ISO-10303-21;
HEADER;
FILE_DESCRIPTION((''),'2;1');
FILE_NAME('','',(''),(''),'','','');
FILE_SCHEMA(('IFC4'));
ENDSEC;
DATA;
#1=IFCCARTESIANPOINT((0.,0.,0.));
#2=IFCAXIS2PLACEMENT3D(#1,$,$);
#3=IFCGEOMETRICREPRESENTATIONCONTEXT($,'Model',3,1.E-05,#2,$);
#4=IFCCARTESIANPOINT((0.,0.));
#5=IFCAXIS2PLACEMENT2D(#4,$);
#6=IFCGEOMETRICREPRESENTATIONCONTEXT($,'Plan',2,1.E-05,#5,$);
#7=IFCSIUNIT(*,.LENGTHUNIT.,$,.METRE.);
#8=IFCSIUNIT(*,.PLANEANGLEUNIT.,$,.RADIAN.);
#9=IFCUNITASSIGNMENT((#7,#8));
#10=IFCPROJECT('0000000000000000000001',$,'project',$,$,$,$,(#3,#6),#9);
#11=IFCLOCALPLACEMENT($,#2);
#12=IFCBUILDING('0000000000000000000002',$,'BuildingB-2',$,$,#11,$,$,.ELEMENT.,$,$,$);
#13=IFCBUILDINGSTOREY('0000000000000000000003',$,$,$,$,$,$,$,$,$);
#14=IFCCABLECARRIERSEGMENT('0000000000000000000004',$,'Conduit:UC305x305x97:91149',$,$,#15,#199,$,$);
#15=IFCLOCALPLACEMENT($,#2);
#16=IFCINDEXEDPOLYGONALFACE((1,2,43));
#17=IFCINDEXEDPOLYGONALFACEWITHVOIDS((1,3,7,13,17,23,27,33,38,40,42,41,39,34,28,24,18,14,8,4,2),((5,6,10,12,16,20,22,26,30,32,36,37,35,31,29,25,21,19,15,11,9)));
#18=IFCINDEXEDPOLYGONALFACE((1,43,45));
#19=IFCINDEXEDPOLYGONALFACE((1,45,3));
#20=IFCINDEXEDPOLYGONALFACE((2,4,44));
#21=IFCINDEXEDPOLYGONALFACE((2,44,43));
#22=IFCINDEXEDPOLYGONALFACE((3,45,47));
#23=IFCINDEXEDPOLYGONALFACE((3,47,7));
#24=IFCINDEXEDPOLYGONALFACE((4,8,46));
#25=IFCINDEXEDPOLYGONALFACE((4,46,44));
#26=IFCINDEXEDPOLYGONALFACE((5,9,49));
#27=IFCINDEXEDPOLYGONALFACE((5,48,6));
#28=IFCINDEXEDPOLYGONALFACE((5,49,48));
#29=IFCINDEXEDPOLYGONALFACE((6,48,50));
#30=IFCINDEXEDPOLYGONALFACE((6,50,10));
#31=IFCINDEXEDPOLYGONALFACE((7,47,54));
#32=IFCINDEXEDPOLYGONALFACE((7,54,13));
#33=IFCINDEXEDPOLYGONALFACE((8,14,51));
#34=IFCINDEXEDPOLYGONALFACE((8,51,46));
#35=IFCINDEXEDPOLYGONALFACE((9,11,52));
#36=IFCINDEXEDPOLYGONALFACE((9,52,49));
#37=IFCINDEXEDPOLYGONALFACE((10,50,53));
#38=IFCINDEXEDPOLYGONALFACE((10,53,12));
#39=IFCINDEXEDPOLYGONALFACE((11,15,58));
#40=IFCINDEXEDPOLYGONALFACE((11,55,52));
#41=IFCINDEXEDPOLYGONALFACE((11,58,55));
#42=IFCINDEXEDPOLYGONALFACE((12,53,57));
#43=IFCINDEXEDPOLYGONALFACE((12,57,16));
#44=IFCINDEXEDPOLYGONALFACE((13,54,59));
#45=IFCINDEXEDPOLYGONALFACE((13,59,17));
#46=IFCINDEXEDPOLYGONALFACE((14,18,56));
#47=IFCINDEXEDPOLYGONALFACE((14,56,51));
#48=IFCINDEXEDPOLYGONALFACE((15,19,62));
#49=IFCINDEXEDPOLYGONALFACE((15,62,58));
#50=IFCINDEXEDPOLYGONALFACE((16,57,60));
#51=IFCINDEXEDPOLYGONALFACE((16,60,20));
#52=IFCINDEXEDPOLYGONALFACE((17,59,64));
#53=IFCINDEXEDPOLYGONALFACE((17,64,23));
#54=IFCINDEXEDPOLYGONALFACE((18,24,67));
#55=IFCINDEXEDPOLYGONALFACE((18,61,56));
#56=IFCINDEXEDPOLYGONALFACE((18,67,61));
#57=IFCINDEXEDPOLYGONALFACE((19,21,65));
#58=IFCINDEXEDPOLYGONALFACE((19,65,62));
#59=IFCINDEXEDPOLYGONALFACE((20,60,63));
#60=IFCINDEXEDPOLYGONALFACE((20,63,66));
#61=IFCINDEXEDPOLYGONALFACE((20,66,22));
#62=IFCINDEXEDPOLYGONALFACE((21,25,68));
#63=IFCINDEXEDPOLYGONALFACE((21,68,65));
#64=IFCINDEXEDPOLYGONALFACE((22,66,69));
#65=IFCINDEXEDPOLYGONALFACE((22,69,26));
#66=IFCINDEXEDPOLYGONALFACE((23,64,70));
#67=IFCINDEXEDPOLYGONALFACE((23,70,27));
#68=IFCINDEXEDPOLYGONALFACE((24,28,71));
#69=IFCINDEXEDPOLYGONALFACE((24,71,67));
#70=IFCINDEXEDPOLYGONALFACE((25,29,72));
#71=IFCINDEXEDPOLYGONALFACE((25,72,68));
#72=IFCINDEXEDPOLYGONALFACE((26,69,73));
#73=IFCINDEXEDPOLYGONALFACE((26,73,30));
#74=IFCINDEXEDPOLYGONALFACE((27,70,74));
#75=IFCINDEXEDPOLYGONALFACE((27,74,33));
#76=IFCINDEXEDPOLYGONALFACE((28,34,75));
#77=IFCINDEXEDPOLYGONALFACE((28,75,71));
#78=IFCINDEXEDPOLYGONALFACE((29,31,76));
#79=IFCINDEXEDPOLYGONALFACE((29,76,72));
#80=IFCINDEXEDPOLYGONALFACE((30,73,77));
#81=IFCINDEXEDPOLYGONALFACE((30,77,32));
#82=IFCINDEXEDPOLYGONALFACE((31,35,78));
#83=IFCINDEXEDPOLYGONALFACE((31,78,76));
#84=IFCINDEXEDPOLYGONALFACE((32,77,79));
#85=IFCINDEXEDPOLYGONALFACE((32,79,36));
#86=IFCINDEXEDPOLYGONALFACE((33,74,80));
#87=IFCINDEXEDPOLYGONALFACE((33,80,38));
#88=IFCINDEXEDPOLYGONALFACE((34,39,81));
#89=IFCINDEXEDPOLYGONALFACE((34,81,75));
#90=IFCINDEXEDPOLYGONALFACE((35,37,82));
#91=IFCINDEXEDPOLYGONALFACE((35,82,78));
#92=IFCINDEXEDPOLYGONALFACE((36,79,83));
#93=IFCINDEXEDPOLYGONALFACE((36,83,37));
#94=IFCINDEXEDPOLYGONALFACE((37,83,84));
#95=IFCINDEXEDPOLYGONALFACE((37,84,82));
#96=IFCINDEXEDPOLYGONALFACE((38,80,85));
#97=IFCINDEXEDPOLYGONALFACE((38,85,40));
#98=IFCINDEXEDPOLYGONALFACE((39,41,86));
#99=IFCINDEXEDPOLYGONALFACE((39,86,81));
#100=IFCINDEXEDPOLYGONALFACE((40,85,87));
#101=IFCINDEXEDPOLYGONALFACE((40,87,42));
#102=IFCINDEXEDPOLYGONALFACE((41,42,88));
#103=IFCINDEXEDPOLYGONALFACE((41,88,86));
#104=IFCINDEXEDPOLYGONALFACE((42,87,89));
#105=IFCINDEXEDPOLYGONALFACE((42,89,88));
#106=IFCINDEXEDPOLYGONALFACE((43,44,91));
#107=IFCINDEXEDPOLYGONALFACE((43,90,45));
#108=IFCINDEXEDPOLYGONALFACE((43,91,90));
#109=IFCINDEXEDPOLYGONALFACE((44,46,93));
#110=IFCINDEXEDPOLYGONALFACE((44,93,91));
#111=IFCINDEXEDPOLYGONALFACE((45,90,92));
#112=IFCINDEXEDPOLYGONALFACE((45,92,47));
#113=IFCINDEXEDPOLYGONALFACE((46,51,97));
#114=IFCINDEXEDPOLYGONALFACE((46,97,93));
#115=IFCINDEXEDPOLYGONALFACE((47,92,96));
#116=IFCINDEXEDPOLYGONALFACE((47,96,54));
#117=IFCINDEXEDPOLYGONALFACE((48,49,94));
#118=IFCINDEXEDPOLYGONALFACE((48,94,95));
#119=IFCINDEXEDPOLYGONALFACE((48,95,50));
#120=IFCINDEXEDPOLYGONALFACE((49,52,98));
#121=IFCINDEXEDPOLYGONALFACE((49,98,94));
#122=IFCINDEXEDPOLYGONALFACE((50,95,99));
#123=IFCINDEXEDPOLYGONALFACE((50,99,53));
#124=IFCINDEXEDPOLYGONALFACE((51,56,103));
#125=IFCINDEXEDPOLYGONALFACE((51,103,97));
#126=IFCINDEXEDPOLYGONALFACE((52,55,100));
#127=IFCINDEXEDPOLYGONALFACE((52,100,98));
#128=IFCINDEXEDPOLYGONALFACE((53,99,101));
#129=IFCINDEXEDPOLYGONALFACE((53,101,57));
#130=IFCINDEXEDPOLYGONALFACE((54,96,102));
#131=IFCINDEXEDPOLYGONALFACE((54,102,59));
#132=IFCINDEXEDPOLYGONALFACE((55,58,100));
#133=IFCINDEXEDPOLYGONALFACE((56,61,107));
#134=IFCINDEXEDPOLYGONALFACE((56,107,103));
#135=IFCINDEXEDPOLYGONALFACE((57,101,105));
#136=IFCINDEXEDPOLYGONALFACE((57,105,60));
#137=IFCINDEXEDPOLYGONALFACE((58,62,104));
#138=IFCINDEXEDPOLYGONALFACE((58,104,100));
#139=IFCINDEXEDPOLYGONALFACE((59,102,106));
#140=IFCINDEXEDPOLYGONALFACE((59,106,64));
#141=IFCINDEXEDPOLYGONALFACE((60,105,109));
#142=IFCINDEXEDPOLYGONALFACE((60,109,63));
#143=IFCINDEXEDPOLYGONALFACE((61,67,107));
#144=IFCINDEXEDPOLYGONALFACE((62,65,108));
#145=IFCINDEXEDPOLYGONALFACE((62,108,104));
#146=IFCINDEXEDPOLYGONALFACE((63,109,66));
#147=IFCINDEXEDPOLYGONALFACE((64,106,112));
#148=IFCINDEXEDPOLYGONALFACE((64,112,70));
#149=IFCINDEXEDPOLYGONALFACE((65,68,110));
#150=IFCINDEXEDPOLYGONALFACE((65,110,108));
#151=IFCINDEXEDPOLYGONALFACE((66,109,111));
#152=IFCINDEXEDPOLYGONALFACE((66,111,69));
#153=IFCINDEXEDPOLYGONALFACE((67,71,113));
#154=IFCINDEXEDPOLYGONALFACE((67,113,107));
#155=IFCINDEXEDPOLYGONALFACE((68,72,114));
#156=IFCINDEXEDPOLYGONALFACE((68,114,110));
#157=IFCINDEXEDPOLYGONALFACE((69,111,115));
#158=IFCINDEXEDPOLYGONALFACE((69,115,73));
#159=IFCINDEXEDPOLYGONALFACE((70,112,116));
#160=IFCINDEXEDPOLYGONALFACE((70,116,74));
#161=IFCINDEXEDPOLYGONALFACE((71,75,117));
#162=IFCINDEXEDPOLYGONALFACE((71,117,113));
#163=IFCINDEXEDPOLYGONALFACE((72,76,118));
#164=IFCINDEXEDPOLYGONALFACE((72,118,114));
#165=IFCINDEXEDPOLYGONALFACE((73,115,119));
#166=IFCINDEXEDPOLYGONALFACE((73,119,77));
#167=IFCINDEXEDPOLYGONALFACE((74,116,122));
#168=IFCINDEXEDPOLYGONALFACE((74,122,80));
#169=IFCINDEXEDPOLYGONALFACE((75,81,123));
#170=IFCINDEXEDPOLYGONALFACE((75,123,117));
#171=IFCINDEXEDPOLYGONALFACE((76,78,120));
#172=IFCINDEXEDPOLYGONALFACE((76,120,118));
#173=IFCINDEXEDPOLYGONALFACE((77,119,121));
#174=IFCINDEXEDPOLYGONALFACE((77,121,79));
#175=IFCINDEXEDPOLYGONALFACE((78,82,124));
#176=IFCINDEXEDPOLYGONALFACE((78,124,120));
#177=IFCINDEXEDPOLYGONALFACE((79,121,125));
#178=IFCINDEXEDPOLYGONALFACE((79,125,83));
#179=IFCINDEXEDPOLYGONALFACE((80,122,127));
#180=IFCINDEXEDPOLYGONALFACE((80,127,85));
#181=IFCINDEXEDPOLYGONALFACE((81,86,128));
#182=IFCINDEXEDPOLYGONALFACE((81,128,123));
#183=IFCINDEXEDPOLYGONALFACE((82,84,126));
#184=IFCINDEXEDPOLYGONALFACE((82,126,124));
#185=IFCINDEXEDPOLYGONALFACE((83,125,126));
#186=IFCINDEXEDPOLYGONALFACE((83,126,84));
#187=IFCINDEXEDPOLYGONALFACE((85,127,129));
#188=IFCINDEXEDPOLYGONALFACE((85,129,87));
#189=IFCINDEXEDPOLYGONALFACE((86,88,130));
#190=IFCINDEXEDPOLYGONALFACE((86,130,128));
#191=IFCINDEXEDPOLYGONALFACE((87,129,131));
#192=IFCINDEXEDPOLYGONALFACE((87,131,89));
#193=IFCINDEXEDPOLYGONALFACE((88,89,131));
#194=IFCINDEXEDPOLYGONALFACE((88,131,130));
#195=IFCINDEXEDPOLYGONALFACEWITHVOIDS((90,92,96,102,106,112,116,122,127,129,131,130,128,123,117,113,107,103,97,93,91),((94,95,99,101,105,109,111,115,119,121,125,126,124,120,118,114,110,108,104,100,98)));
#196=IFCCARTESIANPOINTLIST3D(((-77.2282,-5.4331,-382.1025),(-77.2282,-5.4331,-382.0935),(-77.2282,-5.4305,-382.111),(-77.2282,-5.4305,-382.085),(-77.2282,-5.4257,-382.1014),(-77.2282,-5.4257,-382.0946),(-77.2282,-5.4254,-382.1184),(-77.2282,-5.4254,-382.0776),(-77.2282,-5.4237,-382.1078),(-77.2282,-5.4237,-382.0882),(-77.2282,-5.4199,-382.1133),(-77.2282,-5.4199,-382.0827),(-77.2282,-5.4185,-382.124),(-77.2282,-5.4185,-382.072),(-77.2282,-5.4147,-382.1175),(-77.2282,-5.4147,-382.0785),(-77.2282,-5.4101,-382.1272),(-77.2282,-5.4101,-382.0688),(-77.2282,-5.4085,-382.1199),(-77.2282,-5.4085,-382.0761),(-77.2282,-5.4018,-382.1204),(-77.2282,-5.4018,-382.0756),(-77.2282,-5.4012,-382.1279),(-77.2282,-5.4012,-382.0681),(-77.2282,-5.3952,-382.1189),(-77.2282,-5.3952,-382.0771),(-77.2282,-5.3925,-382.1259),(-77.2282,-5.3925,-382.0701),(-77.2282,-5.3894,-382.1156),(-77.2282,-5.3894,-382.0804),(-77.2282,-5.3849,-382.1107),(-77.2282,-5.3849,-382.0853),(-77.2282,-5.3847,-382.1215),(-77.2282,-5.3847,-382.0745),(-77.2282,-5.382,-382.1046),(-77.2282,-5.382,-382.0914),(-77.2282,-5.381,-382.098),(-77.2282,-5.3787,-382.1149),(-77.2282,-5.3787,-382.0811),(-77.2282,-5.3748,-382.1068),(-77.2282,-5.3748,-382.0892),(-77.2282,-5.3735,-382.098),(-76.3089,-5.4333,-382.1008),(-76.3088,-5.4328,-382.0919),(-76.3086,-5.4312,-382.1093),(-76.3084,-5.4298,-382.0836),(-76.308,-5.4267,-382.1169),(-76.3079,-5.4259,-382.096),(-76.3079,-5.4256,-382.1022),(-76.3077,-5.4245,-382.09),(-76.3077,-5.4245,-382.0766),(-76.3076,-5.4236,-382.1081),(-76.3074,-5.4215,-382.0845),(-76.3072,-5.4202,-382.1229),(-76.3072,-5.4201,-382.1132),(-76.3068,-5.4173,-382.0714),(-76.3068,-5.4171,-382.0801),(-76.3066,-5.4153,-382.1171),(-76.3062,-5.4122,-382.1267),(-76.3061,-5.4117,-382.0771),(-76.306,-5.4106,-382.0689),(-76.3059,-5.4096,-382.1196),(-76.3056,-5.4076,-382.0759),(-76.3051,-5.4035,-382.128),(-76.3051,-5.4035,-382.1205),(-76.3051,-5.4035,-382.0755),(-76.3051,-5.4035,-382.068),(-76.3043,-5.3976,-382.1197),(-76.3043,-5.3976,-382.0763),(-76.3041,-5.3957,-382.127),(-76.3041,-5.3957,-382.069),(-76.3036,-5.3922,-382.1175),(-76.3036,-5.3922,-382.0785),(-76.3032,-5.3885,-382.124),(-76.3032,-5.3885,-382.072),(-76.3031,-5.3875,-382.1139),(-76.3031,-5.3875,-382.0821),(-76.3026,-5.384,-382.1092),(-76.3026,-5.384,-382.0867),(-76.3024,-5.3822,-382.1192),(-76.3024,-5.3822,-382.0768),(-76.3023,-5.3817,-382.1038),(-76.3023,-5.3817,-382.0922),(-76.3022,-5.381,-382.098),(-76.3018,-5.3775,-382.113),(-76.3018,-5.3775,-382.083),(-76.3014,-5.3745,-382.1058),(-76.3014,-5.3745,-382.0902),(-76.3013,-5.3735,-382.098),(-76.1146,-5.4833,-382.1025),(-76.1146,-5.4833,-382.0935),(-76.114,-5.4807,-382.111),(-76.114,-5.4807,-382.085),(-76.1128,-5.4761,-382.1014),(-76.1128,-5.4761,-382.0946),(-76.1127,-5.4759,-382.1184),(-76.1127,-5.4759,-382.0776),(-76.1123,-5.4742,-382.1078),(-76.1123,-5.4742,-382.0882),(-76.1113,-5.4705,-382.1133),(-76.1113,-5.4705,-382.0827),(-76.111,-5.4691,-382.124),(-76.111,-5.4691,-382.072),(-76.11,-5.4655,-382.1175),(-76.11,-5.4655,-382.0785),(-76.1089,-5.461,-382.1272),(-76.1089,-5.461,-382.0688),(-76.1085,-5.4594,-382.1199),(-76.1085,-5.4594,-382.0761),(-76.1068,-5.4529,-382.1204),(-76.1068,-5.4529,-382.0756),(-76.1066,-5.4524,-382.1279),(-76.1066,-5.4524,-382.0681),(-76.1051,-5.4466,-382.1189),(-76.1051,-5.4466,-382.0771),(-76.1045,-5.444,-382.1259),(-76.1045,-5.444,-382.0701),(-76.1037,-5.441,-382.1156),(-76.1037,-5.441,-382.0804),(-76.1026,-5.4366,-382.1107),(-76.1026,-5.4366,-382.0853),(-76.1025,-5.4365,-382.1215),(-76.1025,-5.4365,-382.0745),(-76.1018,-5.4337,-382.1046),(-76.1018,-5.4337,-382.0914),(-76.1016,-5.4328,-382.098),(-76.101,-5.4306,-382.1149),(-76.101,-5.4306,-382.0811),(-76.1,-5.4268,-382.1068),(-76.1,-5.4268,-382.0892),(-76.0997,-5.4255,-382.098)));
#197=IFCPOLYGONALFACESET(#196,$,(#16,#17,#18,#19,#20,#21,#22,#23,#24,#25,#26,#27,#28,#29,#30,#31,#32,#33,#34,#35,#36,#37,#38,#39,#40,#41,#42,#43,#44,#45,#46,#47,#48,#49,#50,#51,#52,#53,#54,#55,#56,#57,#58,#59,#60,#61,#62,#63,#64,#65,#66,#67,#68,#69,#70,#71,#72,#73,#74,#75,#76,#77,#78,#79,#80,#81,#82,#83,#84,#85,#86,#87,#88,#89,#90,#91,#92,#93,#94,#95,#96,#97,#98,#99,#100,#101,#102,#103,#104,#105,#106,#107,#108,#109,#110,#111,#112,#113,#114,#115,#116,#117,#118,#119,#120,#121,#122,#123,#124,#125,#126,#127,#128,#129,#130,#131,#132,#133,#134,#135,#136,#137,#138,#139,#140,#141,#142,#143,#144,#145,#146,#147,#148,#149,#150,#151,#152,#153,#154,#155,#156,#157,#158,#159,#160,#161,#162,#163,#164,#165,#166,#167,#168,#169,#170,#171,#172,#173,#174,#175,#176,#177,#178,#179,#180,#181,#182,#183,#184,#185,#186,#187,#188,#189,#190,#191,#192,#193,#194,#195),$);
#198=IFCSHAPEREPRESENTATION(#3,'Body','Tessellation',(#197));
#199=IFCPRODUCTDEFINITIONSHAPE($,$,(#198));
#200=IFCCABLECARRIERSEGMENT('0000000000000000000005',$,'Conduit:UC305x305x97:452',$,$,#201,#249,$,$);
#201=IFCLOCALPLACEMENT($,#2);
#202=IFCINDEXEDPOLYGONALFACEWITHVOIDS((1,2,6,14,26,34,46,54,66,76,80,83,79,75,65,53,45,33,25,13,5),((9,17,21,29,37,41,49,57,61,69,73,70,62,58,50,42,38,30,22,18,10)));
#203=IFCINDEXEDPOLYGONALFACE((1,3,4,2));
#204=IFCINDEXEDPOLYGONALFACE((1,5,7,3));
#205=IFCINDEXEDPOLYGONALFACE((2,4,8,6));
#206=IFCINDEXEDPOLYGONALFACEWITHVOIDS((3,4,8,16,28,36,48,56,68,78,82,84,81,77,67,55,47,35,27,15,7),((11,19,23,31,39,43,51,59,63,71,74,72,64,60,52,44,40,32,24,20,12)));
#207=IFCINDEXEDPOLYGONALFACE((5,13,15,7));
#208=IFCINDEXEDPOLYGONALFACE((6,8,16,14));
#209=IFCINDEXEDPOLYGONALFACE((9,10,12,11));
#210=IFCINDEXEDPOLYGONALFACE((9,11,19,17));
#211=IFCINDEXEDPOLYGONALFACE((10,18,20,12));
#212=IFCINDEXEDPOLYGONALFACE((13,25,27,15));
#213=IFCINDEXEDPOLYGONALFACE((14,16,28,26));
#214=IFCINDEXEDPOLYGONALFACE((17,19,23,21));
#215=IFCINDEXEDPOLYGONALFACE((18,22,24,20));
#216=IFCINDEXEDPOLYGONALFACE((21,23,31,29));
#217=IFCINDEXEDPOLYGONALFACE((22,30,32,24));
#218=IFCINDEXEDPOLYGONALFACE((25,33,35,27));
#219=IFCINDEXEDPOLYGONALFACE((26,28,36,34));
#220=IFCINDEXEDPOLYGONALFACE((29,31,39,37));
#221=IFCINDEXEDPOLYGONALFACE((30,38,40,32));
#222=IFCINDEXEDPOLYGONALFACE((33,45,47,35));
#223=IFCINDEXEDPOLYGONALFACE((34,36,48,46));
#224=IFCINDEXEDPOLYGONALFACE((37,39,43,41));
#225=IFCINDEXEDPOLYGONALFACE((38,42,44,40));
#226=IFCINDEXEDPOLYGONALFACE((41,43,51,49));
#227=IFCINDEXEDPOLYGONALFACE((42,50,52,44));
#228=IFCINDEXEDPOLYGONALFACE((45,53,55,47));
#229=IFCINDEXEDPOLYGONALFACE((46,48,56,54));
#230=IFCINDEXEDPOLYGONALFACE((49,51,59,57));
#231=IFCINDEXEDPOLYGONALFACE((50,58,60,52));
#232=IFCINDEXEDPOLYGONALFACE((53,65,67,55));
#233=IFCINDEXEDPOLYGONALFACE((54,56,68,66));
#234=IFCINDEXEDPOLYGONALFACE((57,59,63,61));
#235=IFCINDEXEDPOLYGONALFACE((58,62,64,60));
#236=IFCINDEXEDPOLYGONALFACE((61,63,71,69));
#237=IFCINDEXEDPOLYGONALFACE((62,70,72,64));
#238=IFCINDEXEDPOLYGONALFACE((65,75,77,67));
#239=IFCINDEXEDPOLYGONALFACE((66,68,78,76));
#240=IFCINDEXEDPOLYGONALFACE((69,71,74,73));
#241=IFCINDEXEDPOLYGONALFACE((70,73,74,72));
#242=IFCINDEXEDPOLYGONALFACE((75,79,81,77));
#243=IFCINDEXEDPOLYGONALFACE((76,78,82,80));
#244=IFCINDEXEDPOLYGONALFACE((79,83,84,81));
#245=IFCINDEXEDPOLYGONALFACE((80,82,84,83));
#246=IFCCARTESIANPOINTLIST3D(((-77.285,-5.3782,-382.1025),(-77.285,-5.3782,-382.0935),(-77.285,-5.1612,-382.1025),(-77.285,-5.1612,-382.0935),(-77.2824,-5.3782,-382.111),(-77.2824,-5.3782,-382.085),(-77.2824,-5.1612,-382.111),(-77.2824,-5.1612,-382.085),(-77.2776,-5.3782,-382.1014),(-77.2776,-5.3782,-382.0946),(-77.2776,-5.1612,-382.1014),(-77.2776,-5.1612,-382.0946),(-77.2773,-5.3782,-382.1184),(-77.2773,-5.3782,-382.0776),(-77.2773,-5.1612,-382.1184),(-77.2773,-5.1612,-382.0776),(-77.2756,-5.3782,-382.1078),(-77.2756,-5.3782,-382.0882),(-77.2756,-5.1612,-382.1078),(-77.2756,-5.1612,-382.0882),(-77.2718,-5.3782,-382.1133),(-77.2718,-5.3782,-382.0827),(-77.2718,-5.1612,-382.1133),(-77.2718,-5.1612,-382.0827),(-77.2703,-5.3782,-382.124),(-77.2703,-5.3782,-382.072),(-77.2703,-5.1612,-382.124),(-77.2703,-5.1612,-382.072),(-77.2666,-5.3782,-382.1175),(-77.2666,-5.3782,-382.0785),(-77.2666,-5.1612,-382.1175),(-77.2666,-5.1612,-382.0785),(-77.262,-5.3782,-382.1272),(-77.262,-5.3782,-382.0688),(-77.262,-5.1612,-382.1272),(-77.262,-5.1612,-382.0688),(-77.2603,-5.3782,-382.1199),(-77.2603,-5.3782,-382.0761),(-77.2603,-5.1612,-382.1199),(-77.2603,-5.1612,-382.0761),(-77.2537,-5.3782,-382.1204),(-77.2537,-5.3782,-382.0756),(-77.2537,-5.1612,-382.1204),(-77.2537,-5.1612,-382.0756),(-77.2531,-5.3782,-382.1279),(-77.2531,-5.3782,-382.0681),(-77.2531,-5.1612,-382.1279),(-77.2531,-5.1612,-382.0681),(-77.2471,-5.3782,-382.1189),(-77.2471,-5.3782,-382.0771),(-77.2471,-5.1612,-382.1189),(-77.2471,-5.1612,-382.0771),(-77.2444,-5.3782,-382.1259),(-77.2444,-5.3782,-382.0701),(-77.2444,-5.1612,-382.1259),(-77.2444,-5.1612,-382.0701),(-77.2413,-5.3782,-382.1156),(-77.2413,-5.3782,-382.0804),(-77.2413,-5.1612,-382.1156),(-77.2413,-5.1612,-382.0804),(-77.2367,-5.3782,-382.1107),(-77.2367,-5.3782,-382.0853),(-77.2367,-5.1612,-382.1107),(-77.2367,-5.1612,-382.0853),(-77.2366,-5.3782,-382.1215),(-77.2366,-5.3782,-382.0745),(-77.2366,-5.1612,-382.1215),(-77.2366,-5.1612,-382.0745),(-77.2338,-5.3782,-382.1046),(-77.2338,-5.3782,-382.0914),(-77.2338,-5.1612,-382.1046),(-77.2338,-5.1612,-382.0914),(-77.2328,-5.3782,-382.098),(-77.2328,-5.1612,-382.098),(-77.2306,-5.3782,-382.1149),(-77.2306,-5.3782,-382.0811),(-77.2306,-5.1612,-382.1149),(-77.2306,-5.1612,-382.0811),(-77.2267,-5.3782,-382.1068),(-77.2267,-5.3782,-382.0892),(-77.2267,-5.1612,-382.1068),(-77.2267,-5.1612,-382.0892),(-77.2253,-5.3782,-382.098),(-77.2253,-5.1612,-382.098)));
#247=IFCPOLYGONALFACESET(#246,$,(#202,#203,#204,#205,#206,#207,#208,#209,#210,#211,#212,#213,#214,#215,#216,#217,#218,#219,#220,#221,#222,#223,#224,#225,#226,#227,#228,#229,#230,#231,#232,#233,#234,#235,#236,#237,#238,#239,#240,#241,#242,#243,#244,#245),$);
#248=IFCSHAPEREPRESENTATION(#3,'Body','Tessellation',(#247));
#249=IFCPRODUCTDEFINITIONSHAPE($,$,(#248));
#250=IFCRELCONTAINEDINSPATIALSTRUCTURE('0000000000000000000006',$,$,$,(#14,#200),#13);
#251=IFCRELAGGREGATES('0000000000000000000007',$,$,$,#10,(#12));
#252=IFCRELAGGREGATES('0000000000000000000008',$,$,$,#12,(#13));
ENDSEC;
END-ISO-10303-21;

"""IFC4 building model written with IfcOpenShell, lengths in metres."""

from ifc_helpers import new_model, entity, si_unit, origin, origin_2d, place, context, project, spatial, element, save


model = new_model("IFC4")

# Units and contexts
model_context = context("Model", 3, precision=1e-05, world=origin())
plan_context = context("Plan", 2, precision=1e-05, world=origin_2d())
ifc_project = project(units=[si_unit("LENGTHUNIT", "METRE"), si_unit("PLANEANGLEUNIT", "RADIAN")], contexts=[model_context, plan_context])

# Building, storey
building_placement = place(None, origin())
building = spatial("IfcBuilding", under=ifc_project, at=building_placement, Name="BuildingB-2", CompositionType="ELEMENT")
storey = spatial("IfcBuildingStorey", under=building)

# Cable carrier segments
element("IfcCableCarrierSegment", 1, inside=storey, Name="Conduit:UC305x305x97:91149", context=model_context, shape_type="AdvancedSweptSolid", body=[
    entity("IfcSweptDiskSolid", entity("IfcCompositeCurve", [entity("IfcCompositeCurveSegment", "CONTINUOUS", False, entity("IfcPolyline", [entity("IfcCartesianPoint", [75.7446, 5.429, 382.098]), entity("IfcCartesianPoint", [76.6677, 5.429, 382.098]), entity("IfcCartesianPoint", [76.8656, 5.3779, 382.098])]))], False), 0.03, 0.0225),
])
element("IfcCableCarrierSegment", 2, inside=storey, Name="Conduit:UC305x305x97:452", context=model_context, shape_type="AdvancedSweptSolid", body=[
    entity("IfcSweptDiskSolid", entity("IfcCompositeCurve", [entity("IfcCompositeCurveSegment", "CONTINUOUS", False, entity("IfcPolyline", [entity("IfcCartesianPoint", [77.2553, 5.1612, 382.098]), entity("IfcCartesianPoint", [77.2553, 5.3782, 382.098])]))], False), 0.03, 0.0225),
])

save(model, "model.ifc")
